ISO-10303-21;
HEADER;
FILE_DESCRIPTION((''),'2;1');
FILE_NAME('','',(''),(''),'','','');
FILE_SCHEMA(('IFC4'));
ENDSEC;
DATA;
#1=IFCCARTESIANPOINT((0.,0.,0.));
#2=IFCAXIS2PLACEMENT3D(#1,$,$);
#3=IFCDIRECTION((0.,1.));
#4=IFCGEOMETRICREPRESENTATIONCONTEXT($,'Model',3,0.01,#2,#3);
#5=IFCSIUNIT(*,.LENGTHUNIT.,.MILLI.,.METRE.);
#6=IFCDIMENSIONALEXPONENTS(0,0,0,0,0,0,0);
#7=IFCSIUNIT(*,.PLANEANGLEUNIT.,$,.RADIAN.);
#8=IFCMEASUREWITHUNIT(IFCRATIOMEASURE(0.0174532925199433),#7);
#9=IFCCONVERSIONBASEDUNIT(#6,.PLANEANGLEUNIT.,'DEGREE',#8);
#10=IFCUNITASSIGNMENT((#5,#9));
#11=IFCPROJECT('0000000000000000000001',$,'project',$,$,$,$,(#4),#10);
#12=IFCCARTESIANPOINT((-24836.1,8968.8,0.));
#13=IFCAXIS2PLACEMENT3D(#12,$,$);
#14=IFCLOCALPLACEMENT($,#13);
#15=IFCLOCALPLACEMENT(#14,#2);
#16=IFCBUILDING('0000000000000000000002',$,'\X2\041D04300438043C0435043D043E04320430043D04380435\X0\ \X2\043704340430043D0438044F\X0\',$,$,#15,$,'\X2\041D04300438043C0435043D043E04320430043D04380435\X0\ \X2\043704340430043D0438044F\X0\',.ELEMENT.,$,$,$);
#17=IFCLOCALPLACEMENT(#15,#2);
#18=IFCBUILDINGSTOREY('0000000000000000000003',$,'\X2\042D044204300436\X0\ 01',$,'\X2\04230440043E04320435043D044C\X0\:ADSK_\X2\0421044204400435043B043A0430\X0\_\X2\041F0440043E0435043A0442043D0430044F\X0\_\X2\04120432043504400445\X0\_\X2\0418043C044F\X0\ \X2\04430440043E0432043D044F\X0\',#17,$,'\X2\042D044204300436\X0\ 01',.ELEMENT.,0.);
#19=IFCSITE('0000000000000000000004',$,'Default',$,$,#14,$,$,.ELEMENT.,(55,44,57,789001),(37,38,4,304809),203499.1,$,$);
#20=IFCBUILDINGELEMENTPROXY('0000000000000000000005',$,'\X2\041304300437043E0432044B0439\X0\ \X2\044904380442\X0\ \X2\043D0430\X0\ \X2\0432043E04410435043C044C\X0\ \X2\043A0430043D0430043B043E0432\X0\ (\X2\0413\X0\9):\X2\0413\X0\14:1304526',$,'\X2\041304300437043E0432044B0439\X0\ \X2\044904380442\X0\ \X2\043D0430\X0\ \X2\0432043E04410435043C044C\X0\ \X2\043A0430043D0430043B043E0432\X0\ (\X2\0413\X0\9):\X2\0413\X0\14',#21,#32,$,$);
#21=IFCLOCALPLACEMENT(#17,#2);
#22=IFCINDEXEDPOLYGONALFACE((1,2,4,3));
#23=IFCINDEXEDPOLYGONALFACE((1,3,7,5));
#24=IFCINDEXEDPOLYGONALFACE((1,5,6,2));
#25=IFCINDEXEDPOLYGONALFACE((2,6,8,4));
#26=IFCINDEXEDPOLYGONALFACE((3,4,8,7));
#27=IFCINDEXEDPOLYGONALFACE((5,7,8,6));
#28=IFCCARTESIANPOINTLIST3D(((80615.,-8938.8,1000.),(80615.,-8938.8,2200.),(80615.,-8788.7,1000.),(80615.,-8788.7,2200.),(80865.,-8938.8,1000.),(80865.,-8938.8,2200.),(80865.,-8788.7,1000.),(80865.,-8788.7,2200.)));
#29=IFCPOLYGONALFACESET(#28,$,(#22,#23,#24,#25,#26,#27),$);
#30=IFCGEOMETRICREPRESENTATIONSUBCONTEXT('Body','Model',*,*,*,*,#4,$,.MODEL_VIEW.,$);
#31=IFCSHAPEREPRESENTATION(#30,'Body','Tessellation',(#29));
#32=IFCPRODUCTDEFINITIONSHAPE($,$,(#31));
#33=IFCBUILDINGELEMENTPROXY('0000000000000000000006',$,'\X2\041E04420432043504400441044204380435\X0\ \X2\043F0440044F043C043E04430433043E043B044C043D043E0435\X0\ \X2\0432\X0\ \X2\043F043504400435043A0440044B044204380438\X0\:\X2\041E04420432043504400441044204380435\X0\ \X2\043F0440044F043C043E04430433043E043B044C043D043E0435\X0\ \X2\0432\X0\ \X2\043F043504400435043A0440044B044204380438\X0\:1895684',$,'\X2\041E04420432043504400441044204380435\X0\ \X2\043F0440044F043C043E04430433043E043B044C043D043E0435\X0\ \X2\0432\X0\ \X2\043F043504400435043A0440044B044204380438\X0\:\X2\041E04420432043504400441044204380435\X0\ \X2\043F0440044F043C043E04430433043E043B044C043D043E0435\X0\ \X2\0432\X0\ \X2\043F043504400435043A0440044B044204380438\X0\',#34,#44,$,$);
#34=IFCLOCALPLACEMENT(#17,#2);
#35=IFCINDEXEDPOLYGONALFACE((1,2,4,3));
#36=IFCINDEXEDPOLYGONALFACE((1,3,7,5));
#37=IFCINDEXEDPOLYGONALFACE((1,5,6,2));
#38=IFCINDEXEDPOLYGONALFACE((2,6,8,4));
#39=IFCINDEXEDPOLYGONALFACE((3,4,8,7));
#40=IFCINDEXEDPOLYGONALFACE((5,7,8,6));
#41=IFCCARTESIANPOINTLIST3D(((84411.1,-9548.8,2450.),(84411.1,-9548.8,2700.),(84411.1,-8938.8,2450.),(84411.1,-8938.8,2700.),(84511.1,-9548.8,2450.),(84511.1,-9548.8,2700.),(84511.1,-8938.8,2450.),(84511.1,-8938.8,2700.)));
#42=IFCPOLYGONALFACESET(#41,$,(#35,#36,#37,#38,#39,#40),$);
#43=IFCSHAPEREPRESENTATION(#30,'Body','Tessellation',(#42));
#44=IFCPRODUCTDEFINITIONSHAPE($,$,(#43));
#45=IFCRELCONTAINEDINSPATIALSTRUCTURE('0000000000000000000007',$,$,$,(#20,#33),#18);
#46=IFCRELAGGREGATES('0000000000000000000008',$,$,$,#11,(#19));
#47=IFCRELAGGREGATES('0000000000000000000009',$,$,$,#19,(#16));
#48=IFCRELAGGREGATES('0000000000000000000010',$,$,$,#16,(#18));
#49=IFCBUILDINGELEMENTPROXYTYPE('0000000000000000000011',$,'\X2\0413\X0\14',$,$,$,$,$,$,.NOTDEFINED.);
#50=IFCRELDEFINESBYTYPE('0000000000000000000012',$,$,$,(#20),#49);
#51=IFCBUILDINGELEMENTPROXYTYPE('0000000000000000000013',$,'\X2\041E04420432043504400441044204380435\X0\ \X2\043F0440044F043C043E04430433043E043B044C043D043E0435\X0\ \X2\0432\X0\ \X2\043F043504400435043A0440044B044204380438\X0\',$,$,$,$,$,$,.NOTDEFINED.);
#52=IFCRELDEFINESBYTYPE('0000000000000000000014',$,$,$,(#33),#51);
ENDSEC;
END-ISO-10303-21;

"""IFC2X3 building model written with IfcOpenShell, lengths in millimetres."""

from ifc_helpers import new_model, entity, si_unit, converted_unit, direction, frame, origin, origin_2d_with_axis, place, context, subcontext, project, spatial, rectangle, extrude, type_object, element, save


model = new_model("IFC2X3")

# Units and contexts
model_context = context("Model", 3, precision=0.01, world=origin(), true_north=direction((0.0, 1.0)))
body_context = subcontext(model_context, "Body", "Model", "MODEL_VIEW")
ifc_project = project(units=[si_unit("LENGTHUNIT", "METRE", prefix="MILLI"), converted_unit("PLANEANGLEUNIT", "DEGREE", entity("IfcRatioMeasure", 0.0174532925199433), si_unit("PLANEANGLEUNIT", "RADIAN"), dimensions=[0, 0, 0, 0, 0, 0, 0])], contexts=[model_context])

# Site, building, storey
site_placement = place(None, frame((-24836.1, 8968.8, 0.0)))
site = spatial("IfcSite", under=ifc_project, at=site_placement, Name="Default", CompositionType="ELEMENT", RefLatitude=(55, 44, 57, 789001), RefLongitude=(37, 38, 4, 304809), RefElevation=203499.1)
building_placement = place(site_placement, origin())
building = spatial("IfcBuilding", under=site, at=building_placement, Name="Наименование здания", LongName="Наименование здания", CompositionType="ELEMENT")
storey_placement = place(building_placement, origin())
storey = spatial("IfcBuildingStorey", under=building, at=storey_placement, Name="Этаж 01", ObjectType="Уровень:ADSK_Стрелка_Проектная_Вверх_Имя уровня", LongName="Этаж 01", CompositionType="ELEMENT", Elevation=0.0)

# Building element proxies
building_element_proxy_type_1 = type_object("IfcBuildingElementProxyType", Name="Г14", PredefinedType="NOTDEFINED")
proxy_1_placement = place(storey_placement, frame((80615.0, -8938.8, 1000.0)))
element("IfcBuildingElementProxy", 1, at=proxy_1_placement, inside=storey, type_object=building_element_proxy_type_1, Name="Газовый щит на восемь каналов (Г9):Г14:1304526", ObjectType="Газовый щит на восемь каналов (Г9):Г14", context=body_context, shape_type="SweptSolid", body=[
    extrude(rectangle(XDim=250.0, YDim=150.0, at=origin_2d_with_axis()), frame((125.0, 75.0, 0.0), z_axis=(0.0, 0.0, 1.0), x_axis=(-1.0, 0.0, 0.0)), (0.0, 0.0, 1.0), 1200.0),
])
building_element_proxy_type_2 = type_object("IfcBuildingElementProxyType", Name="Отверстие прямоугольное в перекрытии", PredefinedType="NOTDEFINED")
proxy_2_placement = place(storey_placement, frame((84411.1, -9548.8, 2450.0)))
element("IfcBuildingElementProxy", 2, at=proxy_2_placement, inside=storey, type_object=building_element_proxy_type_2, Name="Отверстие прямоугольное в перекрытии:Отверстие прямоугольное в перекрытии:1895684", ObjectType="Отверстие прямоугольное в перекрытии:Отверстие прямоугольное в перекрытии", context=body_context, shape_type="SweptSolid", body=[
    extrude(rectangle(XDim=610.0, YDim=100.0, at=origin_2d_with_axis()), frame((50.0, 305.0, 0.0), z_axis=(0.0, 0.0, 1.0), x_axis=(0.0, -1.0, 0.0)), (0.0, 0.0, 1.0), 250.0),
])

save(model, "model.ifc")
